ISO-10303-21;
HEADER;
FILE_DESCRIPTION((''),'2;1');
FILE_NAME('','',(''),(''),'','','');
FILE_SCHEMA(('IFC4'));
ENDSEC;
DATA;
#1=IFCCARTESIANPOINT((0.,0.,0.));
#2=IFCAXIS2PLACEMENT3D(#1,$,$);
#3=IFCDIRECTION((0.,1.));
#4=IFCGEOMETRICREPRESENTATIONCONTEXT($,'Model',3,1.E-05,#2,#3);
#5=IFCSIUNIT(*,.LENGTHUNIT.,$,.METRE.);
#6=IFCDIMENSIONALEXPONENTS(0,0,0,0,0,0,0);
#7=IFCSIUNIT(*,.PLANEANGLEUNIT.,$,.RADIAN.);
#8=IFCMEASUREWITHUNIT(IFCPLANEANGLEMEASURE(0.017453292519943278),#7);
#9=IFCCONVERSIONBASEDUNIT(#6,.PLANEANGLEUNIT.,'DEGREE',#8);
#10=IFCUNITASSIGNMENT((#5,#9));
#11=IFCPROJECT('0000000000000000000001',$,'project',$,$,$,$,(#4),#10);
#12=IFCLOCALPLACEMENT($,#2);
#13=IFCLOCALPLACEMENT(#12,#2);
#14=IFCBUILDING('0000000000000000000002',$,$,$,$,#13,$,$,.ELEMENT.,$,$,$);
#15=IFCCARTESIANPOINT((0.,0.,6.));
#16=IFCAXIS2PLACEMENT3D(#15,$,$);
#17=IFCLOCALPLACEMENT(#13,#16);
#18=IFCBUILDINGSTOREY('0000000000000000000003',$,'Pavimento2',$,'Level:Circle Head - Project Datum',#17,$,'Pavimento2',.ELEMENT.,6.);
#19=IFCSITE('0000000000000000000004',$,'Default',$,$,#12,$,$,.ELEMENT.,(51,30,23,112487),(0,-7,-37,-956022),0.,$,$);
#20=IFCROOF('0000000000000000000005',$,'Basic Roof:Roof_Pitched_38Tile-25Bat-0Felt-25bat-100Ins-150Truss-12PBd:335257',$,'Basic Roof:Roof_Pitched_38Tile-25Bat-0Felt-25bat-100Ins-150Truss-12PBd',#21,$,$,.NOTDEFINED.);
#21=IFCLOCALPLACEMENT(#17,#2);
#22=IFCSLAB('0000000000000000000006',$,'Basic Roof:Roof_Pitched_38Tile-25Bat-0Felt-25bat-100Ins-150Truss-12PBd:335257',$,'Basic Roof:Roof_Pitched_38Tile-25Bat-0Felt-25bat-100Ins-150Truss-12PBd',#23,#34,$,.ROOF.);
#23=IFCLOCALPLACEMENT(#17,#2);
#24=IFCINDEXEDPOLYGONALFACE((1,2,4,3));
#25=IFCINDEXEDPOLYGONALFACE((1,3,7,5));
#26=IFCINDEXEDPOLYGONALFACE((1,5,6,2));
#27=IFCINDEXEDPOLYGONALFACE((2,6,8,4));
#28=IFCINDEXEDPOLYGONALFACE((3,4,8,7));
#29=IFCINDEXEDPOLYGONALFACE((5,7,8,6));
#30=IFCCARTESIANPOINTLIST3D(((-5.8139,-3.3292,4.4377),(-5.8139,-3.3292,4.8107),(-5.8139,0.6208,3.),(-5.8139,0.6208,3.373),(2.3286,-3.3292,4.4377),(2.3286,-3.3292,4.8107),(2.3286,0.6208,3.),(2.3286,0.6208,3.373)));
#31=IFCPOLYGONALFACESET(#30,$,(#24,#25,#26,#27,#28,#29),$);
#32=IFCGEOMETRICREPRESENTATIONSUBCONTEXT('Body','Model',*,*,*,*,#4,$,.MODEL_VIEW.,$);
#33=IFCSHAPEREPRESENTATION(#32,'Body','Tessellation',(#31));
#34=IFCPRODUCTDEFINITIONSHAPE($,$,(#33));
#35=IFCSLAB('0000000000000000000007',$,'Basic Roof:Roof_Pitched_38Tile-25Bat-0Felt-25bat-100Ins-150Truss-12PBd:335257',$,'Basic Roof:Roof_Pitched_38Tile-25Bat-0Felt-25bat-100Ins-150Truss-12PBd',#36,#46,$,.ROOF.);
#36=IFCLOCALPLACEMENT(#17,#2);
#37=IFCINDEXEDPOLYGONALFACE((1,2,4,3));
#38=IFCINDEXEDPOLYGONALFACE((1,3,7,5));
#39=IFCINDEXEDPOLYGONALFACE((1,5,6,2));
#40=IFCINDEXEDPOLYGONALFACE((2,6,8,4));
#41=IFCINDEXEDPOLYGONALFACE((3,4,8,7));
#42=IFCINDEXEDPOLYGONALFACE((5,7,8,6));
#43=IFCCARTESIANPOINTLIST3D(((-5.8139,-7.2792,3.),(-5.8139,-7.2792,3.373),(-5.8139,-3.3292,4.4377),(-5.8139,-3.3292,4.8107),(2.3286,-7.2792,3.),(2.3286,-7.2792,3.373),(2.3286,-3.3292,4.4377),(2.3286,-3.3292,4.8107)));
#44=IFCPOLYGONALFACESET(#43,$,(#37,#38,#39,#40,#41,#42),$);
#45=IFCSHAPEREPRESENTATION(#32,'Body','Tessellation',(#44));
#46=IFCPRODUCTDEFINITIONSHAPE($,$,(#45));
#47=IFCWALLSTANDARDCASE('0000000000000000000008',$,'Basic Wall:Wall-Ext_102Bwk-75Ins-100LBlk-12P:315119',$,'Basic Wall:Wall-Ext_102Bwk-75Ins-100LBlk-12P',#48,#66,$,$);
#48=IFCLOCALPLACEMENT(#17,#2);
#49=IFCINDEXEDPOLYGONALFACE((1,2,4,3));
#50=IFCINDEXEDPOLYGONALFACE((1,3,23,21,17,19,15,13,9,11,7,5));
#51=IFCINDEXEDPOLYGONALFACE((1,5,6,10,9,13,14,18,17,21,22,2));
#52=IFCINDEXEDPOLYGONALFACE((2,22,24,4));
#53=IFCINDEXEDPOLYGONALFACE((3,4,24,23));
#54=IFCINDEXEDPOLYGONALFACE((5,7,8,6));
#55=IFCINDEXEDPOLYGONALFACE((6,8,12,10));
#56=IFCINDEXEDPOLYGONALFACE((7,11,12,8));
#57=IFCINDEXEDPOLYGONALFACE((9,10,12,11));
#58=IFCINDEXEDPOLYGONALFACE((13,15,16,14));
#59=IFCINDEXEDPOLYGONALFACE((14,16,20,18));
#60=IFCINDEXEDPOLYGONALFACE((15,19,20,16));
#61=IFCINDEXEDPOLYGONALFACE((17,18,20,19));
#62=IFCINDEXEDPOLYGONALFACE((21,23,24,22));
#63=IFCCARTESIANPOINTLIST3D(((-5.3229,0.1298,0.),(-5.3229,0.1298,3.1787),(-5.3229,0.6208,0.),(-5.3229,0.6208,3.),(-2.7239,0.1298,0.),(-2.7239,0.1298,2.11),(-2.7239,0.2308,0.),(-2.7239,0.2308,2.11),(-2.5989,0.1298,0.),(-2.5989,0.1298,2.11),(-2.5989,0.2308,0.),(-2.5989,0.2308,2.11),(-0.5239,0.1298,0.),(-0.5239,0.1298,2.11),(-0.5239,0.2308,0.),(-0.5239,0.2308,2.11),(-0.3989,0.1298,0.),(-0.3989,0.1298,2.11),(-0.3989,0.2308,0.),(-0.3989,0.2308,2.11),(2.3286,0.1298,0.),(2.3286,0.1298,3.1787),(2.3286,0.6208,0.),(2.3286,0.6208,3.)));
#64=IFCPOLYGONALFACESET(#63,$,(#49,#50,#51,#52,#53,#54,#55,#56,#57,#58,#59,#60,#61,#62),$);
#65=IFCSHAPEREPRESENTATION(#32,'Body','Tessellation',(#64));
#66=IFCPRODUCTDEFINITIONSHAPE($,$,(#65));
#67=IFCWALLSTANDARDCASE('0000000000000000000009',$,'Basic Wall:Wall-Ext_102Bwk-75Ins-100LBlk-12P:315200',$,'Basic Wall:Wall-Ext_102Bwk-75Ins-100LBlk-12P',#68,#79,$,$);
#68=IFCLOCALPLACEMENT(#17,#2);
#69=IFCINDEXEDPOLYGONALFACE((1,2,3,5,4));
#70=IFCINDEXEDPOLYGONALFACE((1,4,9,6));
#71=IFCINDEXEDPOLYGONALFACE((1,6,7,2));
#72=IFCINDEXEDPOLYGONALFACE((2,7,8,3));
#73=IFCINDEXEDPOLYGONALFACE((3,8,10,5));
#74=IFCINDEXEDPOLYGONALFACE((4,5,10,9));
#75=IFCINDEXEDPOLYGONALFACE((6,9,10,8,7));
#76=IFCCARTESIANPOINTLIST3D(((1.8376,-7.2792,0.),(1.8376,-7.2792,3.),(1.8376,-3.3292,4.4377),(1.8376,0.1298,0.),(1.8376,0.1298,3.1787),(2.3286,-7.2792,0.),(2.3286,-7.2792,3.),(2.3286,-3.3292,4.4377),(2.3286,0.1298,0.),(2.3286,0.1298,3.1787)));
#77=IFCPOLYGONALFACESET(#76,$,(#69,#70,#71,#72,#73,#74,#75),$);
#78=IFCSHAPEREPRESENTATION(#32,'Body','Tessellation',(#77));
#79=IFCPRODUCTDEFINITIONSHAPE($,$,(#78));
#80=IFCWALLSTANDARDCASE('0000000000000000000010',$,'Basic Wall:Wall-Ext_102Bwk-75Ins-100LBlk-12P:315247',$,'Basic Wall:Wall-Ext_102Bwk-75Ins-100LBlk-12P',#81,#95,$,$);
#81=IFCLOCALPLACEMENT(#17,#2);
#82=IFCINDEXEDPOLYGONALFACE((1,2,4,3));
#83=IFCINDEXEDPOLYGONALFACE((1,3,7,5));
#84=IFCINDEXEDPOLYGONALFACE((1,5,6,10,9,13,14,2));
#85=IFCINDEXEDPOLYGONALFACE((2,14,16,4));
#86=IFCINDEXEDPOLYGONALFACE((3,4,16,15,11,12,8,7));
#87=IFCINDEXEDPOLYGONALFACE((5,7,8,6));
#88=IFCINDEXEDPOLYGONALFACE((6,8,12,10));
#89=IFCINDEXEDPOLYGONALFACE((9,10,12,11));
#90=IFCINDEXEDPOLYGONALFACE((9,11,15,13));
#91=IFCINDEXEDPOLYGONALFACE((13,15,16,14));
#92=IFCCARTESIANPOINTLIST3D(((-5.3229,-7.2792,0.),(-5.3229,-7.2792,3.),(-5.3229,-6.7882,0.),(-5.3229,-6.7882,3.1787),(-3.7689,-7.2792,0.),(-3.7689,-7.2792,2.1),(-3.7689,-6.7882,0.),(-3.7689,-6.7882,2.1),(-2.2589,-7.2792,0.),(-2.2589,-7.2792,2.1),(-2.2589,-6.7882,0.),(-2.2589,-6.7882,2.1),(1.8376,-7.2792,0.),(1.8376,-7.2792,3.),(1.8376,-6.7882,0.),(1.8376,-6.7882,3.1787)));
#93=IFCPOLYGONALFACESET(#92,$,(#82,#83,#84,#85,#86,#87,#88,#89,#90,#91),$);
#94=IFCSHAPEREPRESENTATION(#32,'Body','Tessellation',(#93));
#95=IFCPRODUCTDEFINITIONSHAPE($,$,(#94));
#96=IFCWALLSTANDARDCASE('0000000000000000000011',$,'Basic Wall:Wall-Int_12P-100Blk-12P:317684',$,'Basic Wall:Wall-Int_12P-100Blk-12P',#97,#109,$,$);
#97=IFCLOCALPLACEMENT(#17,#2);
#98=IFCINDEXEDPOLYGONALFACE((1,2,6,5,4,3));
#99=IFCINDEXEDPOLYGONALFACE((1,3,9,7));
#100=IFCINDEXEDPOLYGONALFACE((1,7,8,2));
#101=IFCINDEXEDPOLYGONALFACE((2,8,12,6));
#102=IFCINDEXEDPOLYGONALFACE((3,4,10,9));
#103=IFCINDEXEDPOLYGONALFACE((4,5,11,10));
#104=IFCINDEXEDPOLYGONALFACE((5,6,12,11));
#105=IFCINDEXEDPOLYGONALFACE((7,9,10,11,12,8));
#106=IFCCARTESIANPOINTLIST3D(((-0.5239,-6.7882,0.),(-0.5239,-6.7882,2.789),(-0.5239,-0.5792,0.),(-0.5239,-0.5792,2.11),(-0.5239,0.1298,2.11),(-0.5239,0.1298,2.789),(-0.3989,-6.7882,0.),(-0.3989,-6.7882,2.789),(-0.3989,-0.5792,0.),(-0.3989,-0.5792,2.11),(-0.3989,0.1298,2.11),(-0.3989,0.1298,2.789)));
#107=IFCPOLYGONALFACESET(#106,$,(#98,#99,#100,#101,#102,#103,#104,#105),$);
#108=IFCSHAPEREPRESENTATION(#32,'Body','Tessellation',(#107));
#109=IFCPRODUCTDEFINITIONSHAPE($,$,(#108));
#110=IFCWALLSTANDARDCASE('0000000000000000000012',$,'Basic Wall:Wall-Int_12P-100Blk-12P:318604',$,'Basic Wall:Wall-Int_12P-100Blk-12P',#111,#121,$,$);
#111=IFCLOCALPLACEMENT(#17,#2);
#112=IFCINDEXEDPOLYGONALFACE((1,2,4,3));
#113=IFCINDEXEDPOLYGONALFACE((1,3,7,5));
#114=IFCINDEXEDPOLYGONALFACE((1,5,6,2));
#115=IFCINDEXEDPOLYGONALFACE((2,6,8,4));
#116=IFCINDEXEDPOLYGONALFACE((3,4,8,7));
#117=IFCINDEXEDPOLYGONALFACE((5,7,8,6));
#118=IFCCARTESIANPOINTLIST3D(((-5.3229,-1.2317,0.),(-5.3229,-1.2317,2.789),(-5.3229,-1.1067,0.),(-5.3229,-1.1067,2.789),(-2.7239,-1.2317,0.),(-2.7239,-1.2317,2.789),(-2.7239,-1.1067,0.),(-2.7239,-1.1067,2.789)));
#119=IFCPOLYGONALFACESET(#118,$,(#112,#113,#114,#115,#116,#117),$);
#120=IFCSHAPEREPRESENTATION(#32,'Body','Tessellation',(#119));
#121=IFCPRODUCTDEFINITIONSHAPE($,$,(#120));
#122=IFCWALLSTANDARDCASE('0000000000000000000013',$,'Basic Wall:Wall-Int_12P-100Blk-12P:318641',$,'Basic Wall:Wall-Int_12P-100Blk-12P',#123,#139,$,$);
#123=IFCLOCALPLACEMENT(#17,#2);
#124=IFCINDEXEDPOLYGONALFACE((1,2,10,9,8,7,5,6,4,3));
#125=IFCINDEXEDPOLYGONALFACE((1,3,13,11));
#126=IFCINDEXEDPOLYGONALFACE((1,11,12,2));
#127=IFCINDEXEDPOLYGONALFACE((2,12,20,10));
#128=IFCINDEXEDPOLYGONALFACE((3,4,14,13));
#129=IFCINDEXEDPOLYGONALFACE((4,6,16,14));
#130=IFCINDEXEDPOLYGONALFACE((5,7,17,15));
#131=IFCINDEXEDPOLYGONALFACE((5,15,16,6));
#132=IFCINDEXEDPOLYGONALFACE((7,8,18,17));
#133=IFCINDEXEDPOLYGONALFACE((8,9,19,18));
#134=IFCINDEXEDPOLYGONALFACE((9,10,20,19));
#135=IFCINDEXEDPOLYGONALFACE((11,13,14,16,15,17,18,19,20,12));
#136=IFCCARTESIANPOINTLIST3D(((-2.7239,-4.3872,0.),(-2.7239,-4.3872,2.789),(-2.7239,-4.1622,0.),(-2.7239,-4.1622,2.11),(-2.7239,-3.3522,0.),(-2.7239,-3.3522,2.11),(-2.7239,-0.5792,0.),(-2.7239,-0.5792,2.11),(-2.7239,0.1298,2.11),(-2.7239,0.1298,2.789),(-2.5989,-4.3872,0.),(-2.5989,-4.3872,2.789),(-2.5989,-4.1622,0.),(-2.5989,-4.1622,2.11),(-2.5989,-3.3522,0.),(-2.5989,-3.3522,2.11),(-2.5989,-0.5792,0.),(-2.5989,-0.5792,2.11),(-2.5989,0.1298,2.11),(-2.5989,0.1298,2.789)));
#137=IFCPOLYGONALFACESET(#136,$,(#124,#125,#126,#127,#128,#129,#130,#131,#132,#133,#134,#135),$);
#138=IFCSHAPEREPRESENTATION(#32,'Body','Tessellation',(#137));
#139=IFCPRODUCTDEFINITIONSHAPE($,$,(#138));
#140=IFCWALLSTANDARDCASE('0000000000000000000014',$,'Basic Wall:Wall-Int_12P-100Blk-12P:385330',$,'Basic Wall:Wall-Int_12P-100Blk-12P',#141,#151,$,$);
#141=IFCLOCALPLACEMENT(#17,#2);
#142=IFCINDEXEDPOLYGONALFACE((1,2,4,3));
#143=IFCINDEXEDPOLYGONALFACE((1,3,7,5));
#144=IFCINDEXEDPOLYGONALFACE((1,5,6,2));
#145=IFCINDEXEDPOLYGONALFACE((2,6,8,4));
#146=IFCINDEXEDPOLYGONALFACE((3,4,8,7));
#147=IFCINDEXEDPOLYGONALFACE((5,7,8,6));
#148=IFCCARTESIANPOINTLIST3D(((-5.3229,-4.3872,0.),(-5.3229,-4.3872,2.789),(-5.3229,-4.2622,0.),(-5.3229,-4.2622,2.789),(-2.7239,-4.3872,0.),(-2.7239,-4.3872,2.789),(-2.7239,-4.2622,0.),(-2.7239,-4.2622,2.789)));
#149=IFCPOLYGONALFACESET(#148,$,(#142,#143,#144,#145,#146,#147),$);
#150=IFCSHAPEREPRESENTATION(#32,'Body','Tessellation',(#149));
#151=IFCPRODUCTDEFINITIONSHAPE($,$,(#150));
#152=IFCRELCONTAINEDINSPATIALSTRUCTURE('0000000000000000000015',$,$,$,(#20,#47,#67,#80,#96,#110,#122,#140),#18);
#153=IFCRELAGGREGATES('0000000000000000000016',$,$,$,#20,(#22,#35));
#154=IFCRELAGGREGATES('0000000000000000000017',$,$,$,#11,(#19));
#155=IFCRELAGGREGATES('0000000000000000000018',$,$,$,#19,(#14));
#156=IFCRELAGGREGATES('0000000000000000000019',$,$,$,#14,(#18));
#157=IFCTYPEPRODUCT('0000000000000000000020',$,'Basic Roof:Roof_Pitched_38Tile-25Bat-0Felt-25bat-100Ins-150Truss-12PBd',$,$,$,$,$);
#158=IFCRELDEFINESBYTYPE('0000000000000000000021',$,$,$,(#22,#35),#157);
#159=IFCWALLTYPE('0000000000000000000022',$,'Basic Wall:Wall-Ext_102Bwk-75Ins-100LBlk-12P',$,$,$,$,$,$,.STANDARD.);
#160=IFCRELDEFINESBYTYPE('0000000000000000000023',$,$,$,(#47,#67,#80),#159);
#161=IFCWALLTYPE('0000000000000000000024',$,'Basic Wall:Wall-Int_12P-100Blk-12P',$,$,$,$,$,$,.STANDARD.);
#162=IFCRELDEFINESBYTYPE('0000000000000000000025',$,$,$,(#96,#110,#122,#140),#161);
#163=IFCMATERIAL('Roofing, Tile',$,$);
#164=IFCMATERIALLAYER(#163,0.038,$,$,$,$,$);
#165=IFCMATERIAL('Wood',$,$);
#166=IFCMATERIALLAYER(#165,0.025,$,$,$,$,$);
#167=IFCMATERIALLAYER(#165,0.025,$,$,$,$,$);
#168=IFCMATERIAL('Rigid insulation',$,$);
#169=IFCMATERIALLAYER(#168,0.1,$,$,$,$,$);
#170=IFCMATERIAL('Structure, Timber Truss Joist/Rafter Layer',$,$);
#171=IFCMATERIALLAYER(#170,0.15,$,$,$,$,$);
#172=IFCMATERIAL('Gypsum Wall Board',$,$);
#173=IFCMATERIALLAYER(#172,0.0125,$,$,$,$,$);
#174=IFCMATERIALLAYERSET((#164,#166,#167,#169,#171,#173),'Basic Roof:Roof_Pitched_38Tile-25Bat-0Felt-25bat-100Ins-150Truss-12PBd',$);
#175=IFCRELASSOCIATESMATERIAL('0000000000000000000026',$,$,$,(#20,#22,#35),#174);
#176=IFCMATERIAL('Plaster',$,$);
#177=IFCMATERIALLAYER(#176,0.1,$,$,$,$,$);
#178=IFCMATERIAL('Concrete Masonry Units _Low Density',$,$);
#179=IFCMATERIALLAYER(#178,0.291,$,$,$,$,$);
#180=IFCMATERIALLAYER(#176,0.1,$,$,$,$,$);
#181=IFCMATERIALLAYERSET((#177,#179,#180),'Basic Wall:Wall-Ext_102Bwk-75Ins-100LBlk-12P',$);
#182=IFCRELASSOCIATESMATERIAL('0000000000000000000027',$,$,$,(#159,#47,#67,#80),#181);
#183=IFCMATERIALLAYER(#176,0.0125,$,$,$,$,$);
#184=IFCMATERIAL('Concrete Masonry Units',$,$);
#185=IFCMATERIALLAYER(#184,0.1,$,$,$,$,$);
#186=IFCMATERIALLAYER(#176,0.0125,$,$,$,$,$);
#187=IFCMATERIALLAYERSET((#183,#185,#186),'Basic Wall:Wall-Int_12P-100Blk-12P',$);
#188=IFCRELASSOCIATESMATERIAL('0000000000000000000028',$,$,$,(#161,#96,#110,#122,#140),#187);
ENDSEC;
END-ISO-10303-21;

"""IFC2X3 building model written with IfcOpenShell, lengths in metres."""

from ifc_helpers import new_model, entity, si_unit, converted_unit, direction, frame, frame_2d, origin, place, context, subcontext, project, spatial, polyline, rectangle, extrude, clip, bounded_halfspace, material, layer, layer_set, layer_usage, type_object, element, aggregate, save


model = new_model("IFC2X3")

# Units and contexts
model_context = context("Model", 3, precision=1e-05, world=origin(), true_north=direction((0.0, 1.0)))
body_context = subcontext(model_context, "Body", "Model", "MODEL_VIEW")
ifc_project = project(units=[si_unit("LENGTHUNIT", "METRE"), converted_unit("PLANEANGLEUNIT", "DEGREE", entity("IfcPlaneAngleMeasure", 0.017453292519943278), si_unit("PLANEANGLEUNIT", "RADIAN"), dimensions=[0, 0, 0, 0, 0, 0, 0])], contexts=[model_context])

# Site, building, storey
site_placement = place(None, origin())
site = spatial("IfcSite", under=ifc_project, at=site_placement, Name="Default", CompositionType="ELEMENT", RefLatitude=(51, 30, 23, 112487), RefLongitude=(0, -7, -37, -956022), RefElevation=0.0)
building_placement = place(site_placement, origin())
building = spatial("IfcBuilding", under=site, at=building_placement, CompositionType="ELEMENT")
storey_placement = place(building_placement, frame((0.0, 0.0, 6.0)))
storey = spatial("IfcBuildingStorey", under=building, at=storey_placement, Name="Pavimento2", ObjectType="Level:Circle Head - Project Datum", LongName="Pavimento2", CompositionType="ELEMENT", Elevation=6.0)

# Roof, slabs
ifc_material_1 = material(Name="Roofing, Tile")
ifc_layer_1 = layer(ifc_material_1, 0.038)
ifc_material_2 = material(Name="Wood")
ifc_layer_2 = layer(ifc_material_2, 0.025)
ifc_layer_3 = layer(ifc_material_2, 0.025)
ifc_material_3 = material(Name="Rigid insulation")
ifc_layer_4 = layer(ifc_material_3, 0.1)
ifc_material_4 = material(Name="Structure, Timber Truss Joist/Rafter Layer")
ifc_layer_5 = layer(ifc_material_4, 0.15)
ifc_material_5 = material(Name="Gypsum Wall Board")
ifc_layer_6 = layer(ifc_material_5, 0.0125)
ifc_layer_set_1 = layer_set([ifc_layer_1, ifc_layer_2, ifc_layer_3, ifc_layer_4, ifc_layer_5, ifc_layer_6], Name="Basic Roof:Roof_Pitched_38Tile-25Bat-0Felt-25bat-100Ins-150Truss-12PBd")
roof_placement = place(storey_placement, frame((-5.8139, -7.2792, 3.0)))
roof = element("IfcRoof", 1, at=roof_placement, inside=storey, material=ifc_layer_set_1, Name="Basic Roof:Roof_Pitched_38Tile-25Bat-0Felt-25bat-100Ins-150Truss-12PBd:335257", ObjectType="Basic Roof:Roof_Pitched_38Tile-25Bat-0Felt-25bat-100Ins-150Truss-12PBd", ShapeType="NOTDEFINED")
type_product = type_object("IfcTypeProduct", Name="Basic Roof:Roof_Pitched_38Tile-25Bat-0Felt-25bat-100Ins-150Truss-12PBd")
slab_1_placement = place(roof_placement, origin())
slab_1 = element("IfcSlab", 2, at=slab_1_placement, type_object=type_product, material=ifc_layer_set_1, Name="Basic Roof:Roof_Pitched_38Tile-25Bat-0Felt-25bat-100Ins-150Truss-12PBd:335257", ObjectType="Basic Roof:Roof_Pitched_38Tile-25Bat-0Felt-25bat-100Ins-150Truss-12PBd", PredefinedType="ROOF", context=body_context, shape_type="SweptSolid", body=[
    extrude(rectangle(XDim=8.1425, YDim=4.2035, at=frame_2d((0.0, 0.0), x_axis=(1.0, 0.0))), frame((4.0713, 5.925, 0.7188), z_axis=(0.0, 0.34202, 0.939693), x_axis=(1.0, 0.0, 0.0)), (0.0, -0.34202, 0.939693), 0.373),
])
slab_2_placement = place(roof_placement, origin())
slab_2 = element("IfcSlab", 3, at=slab_2_placement, type_object=type_product, material=ifc_layer_set_1, Name="Basic Roof:Roof_Pitched_38Tile-25Bat-0Felt-25bat-100Ins-150Truss-12PBd:335257", ObjectType="Basic Roof:Roof_Pitched_38Tile-25Bat-0Felt-25bat-100Ins-150Truss-12PBd", PredefinedType="ROOF", context=body_context, shape_type="SweptSolid", body=[
    extrude(rectangle(XDim=4.2035, YDim=8.1425, at=frame_2d((0.0, 0.0), x_axis=(0.0, 1.0))), frame((4.0713, 1.975, 0.7188), z_axis=(0.0, -0.34202, 0.939693), x_axis=(1.0, 0.0, 0.0)), (0.0, 0.34202, 0.939693), 0.373),
])
aggregate(roof, [slab_1, slab_2])

# Wall, openings
ifc_material_6 = material(Name="Plaster")
ifc_layer_7 = layer(ifc_material_6, 0.1)
ifc_material_7 = material(Name="Concrete Masonry Units _Low Density")
ifc_layer_8 = layer(ifc_material_7, 0.291)
ifc_layer_9 = layer(ifc_material_6, 0.1)
ifc_layer_set_2 = layer_set([ifc_layer_7, ifc_layer_8, ifc_layer_9], Name="Basic Wall:Wall-Ext_102Bwk-75Ins-100LBlk-12P")
ifc_layer_usage_1 = layer_usage(ifc_layer_set_2, "AXIS2", "NEGATIVE", 0.2455)
wall_type_1 = type_object("IfcWallType", Name="Basic Wall:Wall-Ext_102Bwk-75Ins-100LBlk-12P", PredefinedType="STANDARD", material=ifc_layer_set_2)
wall_1_placement = place(storey_placement, frame((-5.3229, 0.3753, 0.0)))
wall_1 = element("IfcWallStandardCase", 4, at=wall_1_placement, inside=storey, type_object=wall_type_1, material=ifc_layer_usage_1, Name="Basic Wall:Wall-Ext_102Bwk-75Ins-100LBlk-12P:315119", ObjectType="Basic Wall:Wall-Ext_102Bwk-75Ins-100LBlk-12P", context=body_context, shape_type="Clipping", body=[
    clip(extrude(rectangle(XDim=7.6515, YDim=0.491, at=frame_2d((3.8258, 0.0), x_axis=(-1.0, 0.0))), origin(), (0.0, 0.0, 1.0), 3.1787), bounded_halfspace(frame((0.0, -0.2455, 3.1787), z_axis=(0.0, 0.34202, 0.939693), x_axis=(-1.0, 0.0, 0.0)), False, frame((0.0, -0.2455, 3.1787)), polyline([(0.0, 0.0), (7.1605, 0.0), (7.6515, 0.0), (7.6515, 0.491), (0.0, 0.491), (0.0, 0.0)]))),
])
opening_1_placement = place(wall_1_placement, origin())
element("IfcOpeningElement", 5, at=opening_1_placement, cuts=wall_1, ObjectType="Opening", context=body_context, shape_type="SweptSolid", body=[
    extrude(rectangle(XDim=2.11, YDim=0.125, at=frame_2d((0.0, 0.0), x_axis=(0.0, 1.0))), frame((2.6615, -0.9545, 1.055), z_axis=(0.0, 1.0, 0.0), x_axis=(-1.0, 0.0, 0.0)), (0.0, 0.0, 1.0), 0.81),
])
opening_2_placement = place(wall_1_placement, origin())
element("IfcOpeningElement", 6, at=opening_2_placement, cuts=wall_1, ObjectType="Opening", context=body_context, shape_type="SweptSolid", body=[
    extrude(rectangle(XDim=2.11, YDim=0.125, at=frame_2d((0.0, 0.0), x_axis=(0.0, 1.0))), frame((4.8615, -0.9545, 1.055), z_axis=(0.0, 1.0, 0.0), x_axis=(-1.0, 0.0, 0.0)), (0.0, 0.0, 1.0), 0.81),
])

# Wall
wall_2_placement = place(storey_placement, frame((2.0831, 0.1298, 0.0), z_axis=(0.0, 0.0, 1.0), x_axis=(0.0, -1.0, 0.0)))
element("IfcWallStandardCase", 7, at=wall_2_placement, inside=storey, type_object=wall_type_1, material=ifc_layer_usage_1, Name="Basic Wall:Wall-Ext_102Bwk-75Ins-100LBlk-12P:315200", ObjectType="Basic Wall:Wall-Ext_102Bwk-75Ins-100LBlk-12P", context=body_context, shape_type="Clipping", body=[
    clip(clip(extrude(rectangle(XDim=7.409, YDim=0.491, at=frame_2d((3.7045, 0.0), x_axis=(-1.0, 0.0))), origin(), (0.0, 0.0, 1.0), 4.4377), bounded_halfspace(frame((0.0, -0.2455, 3.1787), z_axis=(-0.34202, 0.0, 0.939693), x_axis=(0.0, -1.0, 0.0)), False, frame((0.0, -0.2455, 3.1787)), polyline([(0.0, 0.0), (3.459, 0.0), (3.459, 0.491), (0.0, 0.491), (0.0, 0.0)]))), bounded_halfspace(frame((3.459, -0.2455, 4.4377), z_axis=(0.34202, 0.0, 0.939693), x_axis=(0.0, 1.0, 0.0)), False, frame((3.459, -0.2455, 4.4377)), polyline([(0.0, 0.0), (3.459, 0.0), (3.95, 0.0), (3.95, 0.491), (0.0, 0.491), (0.0, 0.0)]))),
])

# Walls, openings
wall_3_placement = place(storey_placement, frame((1.8376, -7.0337, 0.0), z_axis=(0.0, 0.0, 1.0), x_axis=(-1.0, 0.0, 0.0)))
wall_3 = element("IfcWallStandardCase", 8, at=wall_3_placement, inside=storey, type_object=wall_type_1, material=ifc_layer_usage_1, Name="Basic Wall:Wall-Ext_102Bwk-75Ins-100LBlk-12P:315247", ObjectType="Basic Wall:Wall-Ext_102Bwk-75Ins-100LBlk-12P", context=body_context, shape_type="Clipping", body=[
    clip(extrude(rectangle(XDim=7.1605, YDim=0.491, at=frame_2d((3.5803, 0.0), x_axis=(1.0, 0.0))), origin(), (0.0, 0.0, 1.0), 3.1787), bounded_halfspace(frame((0.0, -0.2455, 3.1787), z_axis=(0.0, 0.34202, 0.939693), x_axis=(-1.0, 0.0, 0.0)), False, frame((0.0, -0.2455, 3.1787)), polyline([(0.0, 0.0), (7.1605, 0.0), (7.1605, 0.491), (0.0, 0.491), (0.0, 0.0)]))),
])
opening_3_placement = place(wall_3_placement, frame((1.8376, -7.0337, 0.0), z_axis=(0.0, 0.0, 1.0), x_axis=(-1.0, 0.0, 0.0)))
element("IfcOpeningElement", 9, at=opening_3_placement, cuts=wall_3, ObjectType="Opening", context=body_context, shape_type="SweptSolid", body=[
    extrude(rectangle(XDim=2.1, YDim=1.51, at=frame_2d((0.0, 0.0), x_axis=(0.0, 1.0))), frame((-3.0139, -6.4882, 1.05), z_axis=(0.0, -1.0, 0.0), x_axis=(-1.0, 0.0, 0.0)), (0.0, 0.0, 1.0), 1.091),
])
ifc_layer_10 = layer(ifc_material_6, 0.0125)
ifc_material_8 = material(Name="Concrete Masonry Units")
ifc_layer_11 = layer(ifc_material_8, 0.1)
ifc_layer_12 = layer(ifc_material_6, 0.0125)
ifc_layer_set_3 = layer_set([ifc_layer_10, ifc_layer_11, ifc_layer_12], Name="Basic Wall:Wall-Int_12P-100Blk-12P")
ifc_layer_usage_2 = layer_usage(ifc_layer_set_3, "AXIS2", "NEGATIVE", 0.0625)
wall_type_2 = type_object("IfcWallType", Name="Basic Wall:Wall-Int_12P-100Blk-12P", PredefinedType="STANDARD", material=ifc_layer_set_3)
wall_4_placement = place(storey_placement, frame((-0.4614, 0.1298, 0.0), z_axis=(0.0, 0.0, 1.0), x_axis=(0.0, -1.0, 0.0)))
wall_4 = element("IfcWallStandardCase", 10, at=wall_4_placement, inside=storey, type_object=wall_type_2, material=ifc_layer_usage_2, Name="Basic Wall:Wall-Int_12P-100Blk-12P:317684", ObjectType="Basic Wall:Wall-Int_12P-100Blk-12P", context=body_context, shape_type="SweptSolid", body=[
    extrude(rectangle(XDim=6.918, YDim=0.125, at=frame_2d((3.459, 0.0), x_axis=(-1.0, 0.0))), origin(), (0.0, 0.0, 1.0), 2.789),
])
opening_4_placement = place(wall_4_placement, frame((0.709, 0.0625, 0.0)))
element("IfcOpeningElement", 11, at=opening_4_placement, cuts=wall_4, ObjectType="Opening", context=body_context, shape_type="SweptSolid", body=[
    extrude(rectangle(XDim=2.11, YDim=0.81, at=frame_2d((1.055, 0.405), x_axis=(1.0, 0.0))), frame((0.0, 0.0, 0.0), z_axis=(0.0, -1.0, 0.0), x_axis=(0.0, 0.0, 1.0)), (0.0, 0.0, 1.0), 0.125),
])

# Wall
wall_5_placement = place(storey_placement, frame((-2.7239, -1.1692, 0.0), z_axis=(0.0, 0.0, 1.0), x_axis=(-1.0, 0.0, 0.0)))
element("IfcWallStandardCase", 12, at=wall_5_placement, inside=storey, type_object=wall_type_2, material=ifc_layer_usage_2, Name="Basic Wall:Wall-Int_12P-100Blk-12P:318604", ObjectType="Basic Wall:Wall-Int_12P-100Blk-12P", context=body_context, shape_type="SweptSolid", body=[
    extrude(rectangle(XDim=2.599, YDim=0.125, at=frame_2d((1.2995, 0.0), x_axis=(-1.0, 0.0))), origin(), (0.0, 0.0, 1.0), 2.789),
])

# Wall, openings
wall_6_placement = place(storey_placement, frame((-2.6614, 0.1298, 0.0), z_axis=(0.0, 0.0, 1.0), x_axis=(0.0, -1.0, 0.0)))
wall_6 = element("IfcWallStandardCase", 13, at=wall_6_placement, inside=storey, type_object=wall_type_2, material=ifc_layer_usage_2, Name="Basic Wall:Wall-Int_12P-100Blk-12P:318641", ObjectType="Basic Wall:Wall-Int_12P-100Blk-12P", context=body_context, shape_type="SweptSolid", body=[
    extrude(rectangle(XDim=4.517, YDim=0.125, at=frame_2d((2.2585, 0.0), x_axis=(-1.0, 0.0))), origin(), (0.0, 0.0, 1.0), 2.789),
])
opening_5_placement = place(wall_6_placement, frame((0.709, 0.0625, 0.0)))
element("IfcOpeningElement", 14, at=opening_5_placement, cuts=wall_6, ObjectType="Opening", context=body_context, shape_type="SweptSolid", body=[
    extrude(rectangle(XDim=2.11, YDim=0.81, at=frame_2d((1.055, 0.405), x_axis=(1.0, 0.0))), frame((0.0, 0.0, 0.0), z_axis=(0.0, -1.0, 0.0), x_axis=(0.0, 0.0, 1.0)), (0.0, 0.0, 1.0), 0.125),
])
opening_6_placement = place(wall_6_placement, frame((4.292, 0.0625, 0.0)))
element("IfcOpeningElement", 15, at=opening_6_placement, cuts=wall_6, ObjectType="Opening", context=body_context, shape_type="SweptSolid", body=[
    extrude(rectangle(XDim=2.11, YDim=0.81, at=frame_2d((1.055, 0.405), x_axis=(1.0, 0.0))), frame((0.0, 0.0, 0.0), z_axis=(0.0, -1.0, 0.0), x_axis=(0.0, 0.0, 1.0)), (0.0, 0.0, 1.0), 0.125),
])

# Wall
wall_7_placement = place(storey_placement, frame((-2.7239, -4.3247, 0.0), z_axis=(0.0, 0.0, 1.0), x_axis=(-1.0, 0.0, 0.0)))
element("IfcWallStandardCase", 16, at=wall_7_placement, inside=storey, type_object=wall_type_2, material=ifc_layer_usage_2, Name="Basic Wall:Wall-Int_12P-100Blk-12P:385330", ObjectType="Basic Wall:Wall-Int_12P-100Blk-12P", context=body_context, shape_type="SweptSolid", body=[
    extrude(rectangle(XDim=2.599, YDim=0.125, at=frame_2d((1.2995, 0.0), x_axis=(-1.0, 0.0))), origin(), (0.0, 0.0, 1.0), 2.789),
])

save(model, "model.ifc")
